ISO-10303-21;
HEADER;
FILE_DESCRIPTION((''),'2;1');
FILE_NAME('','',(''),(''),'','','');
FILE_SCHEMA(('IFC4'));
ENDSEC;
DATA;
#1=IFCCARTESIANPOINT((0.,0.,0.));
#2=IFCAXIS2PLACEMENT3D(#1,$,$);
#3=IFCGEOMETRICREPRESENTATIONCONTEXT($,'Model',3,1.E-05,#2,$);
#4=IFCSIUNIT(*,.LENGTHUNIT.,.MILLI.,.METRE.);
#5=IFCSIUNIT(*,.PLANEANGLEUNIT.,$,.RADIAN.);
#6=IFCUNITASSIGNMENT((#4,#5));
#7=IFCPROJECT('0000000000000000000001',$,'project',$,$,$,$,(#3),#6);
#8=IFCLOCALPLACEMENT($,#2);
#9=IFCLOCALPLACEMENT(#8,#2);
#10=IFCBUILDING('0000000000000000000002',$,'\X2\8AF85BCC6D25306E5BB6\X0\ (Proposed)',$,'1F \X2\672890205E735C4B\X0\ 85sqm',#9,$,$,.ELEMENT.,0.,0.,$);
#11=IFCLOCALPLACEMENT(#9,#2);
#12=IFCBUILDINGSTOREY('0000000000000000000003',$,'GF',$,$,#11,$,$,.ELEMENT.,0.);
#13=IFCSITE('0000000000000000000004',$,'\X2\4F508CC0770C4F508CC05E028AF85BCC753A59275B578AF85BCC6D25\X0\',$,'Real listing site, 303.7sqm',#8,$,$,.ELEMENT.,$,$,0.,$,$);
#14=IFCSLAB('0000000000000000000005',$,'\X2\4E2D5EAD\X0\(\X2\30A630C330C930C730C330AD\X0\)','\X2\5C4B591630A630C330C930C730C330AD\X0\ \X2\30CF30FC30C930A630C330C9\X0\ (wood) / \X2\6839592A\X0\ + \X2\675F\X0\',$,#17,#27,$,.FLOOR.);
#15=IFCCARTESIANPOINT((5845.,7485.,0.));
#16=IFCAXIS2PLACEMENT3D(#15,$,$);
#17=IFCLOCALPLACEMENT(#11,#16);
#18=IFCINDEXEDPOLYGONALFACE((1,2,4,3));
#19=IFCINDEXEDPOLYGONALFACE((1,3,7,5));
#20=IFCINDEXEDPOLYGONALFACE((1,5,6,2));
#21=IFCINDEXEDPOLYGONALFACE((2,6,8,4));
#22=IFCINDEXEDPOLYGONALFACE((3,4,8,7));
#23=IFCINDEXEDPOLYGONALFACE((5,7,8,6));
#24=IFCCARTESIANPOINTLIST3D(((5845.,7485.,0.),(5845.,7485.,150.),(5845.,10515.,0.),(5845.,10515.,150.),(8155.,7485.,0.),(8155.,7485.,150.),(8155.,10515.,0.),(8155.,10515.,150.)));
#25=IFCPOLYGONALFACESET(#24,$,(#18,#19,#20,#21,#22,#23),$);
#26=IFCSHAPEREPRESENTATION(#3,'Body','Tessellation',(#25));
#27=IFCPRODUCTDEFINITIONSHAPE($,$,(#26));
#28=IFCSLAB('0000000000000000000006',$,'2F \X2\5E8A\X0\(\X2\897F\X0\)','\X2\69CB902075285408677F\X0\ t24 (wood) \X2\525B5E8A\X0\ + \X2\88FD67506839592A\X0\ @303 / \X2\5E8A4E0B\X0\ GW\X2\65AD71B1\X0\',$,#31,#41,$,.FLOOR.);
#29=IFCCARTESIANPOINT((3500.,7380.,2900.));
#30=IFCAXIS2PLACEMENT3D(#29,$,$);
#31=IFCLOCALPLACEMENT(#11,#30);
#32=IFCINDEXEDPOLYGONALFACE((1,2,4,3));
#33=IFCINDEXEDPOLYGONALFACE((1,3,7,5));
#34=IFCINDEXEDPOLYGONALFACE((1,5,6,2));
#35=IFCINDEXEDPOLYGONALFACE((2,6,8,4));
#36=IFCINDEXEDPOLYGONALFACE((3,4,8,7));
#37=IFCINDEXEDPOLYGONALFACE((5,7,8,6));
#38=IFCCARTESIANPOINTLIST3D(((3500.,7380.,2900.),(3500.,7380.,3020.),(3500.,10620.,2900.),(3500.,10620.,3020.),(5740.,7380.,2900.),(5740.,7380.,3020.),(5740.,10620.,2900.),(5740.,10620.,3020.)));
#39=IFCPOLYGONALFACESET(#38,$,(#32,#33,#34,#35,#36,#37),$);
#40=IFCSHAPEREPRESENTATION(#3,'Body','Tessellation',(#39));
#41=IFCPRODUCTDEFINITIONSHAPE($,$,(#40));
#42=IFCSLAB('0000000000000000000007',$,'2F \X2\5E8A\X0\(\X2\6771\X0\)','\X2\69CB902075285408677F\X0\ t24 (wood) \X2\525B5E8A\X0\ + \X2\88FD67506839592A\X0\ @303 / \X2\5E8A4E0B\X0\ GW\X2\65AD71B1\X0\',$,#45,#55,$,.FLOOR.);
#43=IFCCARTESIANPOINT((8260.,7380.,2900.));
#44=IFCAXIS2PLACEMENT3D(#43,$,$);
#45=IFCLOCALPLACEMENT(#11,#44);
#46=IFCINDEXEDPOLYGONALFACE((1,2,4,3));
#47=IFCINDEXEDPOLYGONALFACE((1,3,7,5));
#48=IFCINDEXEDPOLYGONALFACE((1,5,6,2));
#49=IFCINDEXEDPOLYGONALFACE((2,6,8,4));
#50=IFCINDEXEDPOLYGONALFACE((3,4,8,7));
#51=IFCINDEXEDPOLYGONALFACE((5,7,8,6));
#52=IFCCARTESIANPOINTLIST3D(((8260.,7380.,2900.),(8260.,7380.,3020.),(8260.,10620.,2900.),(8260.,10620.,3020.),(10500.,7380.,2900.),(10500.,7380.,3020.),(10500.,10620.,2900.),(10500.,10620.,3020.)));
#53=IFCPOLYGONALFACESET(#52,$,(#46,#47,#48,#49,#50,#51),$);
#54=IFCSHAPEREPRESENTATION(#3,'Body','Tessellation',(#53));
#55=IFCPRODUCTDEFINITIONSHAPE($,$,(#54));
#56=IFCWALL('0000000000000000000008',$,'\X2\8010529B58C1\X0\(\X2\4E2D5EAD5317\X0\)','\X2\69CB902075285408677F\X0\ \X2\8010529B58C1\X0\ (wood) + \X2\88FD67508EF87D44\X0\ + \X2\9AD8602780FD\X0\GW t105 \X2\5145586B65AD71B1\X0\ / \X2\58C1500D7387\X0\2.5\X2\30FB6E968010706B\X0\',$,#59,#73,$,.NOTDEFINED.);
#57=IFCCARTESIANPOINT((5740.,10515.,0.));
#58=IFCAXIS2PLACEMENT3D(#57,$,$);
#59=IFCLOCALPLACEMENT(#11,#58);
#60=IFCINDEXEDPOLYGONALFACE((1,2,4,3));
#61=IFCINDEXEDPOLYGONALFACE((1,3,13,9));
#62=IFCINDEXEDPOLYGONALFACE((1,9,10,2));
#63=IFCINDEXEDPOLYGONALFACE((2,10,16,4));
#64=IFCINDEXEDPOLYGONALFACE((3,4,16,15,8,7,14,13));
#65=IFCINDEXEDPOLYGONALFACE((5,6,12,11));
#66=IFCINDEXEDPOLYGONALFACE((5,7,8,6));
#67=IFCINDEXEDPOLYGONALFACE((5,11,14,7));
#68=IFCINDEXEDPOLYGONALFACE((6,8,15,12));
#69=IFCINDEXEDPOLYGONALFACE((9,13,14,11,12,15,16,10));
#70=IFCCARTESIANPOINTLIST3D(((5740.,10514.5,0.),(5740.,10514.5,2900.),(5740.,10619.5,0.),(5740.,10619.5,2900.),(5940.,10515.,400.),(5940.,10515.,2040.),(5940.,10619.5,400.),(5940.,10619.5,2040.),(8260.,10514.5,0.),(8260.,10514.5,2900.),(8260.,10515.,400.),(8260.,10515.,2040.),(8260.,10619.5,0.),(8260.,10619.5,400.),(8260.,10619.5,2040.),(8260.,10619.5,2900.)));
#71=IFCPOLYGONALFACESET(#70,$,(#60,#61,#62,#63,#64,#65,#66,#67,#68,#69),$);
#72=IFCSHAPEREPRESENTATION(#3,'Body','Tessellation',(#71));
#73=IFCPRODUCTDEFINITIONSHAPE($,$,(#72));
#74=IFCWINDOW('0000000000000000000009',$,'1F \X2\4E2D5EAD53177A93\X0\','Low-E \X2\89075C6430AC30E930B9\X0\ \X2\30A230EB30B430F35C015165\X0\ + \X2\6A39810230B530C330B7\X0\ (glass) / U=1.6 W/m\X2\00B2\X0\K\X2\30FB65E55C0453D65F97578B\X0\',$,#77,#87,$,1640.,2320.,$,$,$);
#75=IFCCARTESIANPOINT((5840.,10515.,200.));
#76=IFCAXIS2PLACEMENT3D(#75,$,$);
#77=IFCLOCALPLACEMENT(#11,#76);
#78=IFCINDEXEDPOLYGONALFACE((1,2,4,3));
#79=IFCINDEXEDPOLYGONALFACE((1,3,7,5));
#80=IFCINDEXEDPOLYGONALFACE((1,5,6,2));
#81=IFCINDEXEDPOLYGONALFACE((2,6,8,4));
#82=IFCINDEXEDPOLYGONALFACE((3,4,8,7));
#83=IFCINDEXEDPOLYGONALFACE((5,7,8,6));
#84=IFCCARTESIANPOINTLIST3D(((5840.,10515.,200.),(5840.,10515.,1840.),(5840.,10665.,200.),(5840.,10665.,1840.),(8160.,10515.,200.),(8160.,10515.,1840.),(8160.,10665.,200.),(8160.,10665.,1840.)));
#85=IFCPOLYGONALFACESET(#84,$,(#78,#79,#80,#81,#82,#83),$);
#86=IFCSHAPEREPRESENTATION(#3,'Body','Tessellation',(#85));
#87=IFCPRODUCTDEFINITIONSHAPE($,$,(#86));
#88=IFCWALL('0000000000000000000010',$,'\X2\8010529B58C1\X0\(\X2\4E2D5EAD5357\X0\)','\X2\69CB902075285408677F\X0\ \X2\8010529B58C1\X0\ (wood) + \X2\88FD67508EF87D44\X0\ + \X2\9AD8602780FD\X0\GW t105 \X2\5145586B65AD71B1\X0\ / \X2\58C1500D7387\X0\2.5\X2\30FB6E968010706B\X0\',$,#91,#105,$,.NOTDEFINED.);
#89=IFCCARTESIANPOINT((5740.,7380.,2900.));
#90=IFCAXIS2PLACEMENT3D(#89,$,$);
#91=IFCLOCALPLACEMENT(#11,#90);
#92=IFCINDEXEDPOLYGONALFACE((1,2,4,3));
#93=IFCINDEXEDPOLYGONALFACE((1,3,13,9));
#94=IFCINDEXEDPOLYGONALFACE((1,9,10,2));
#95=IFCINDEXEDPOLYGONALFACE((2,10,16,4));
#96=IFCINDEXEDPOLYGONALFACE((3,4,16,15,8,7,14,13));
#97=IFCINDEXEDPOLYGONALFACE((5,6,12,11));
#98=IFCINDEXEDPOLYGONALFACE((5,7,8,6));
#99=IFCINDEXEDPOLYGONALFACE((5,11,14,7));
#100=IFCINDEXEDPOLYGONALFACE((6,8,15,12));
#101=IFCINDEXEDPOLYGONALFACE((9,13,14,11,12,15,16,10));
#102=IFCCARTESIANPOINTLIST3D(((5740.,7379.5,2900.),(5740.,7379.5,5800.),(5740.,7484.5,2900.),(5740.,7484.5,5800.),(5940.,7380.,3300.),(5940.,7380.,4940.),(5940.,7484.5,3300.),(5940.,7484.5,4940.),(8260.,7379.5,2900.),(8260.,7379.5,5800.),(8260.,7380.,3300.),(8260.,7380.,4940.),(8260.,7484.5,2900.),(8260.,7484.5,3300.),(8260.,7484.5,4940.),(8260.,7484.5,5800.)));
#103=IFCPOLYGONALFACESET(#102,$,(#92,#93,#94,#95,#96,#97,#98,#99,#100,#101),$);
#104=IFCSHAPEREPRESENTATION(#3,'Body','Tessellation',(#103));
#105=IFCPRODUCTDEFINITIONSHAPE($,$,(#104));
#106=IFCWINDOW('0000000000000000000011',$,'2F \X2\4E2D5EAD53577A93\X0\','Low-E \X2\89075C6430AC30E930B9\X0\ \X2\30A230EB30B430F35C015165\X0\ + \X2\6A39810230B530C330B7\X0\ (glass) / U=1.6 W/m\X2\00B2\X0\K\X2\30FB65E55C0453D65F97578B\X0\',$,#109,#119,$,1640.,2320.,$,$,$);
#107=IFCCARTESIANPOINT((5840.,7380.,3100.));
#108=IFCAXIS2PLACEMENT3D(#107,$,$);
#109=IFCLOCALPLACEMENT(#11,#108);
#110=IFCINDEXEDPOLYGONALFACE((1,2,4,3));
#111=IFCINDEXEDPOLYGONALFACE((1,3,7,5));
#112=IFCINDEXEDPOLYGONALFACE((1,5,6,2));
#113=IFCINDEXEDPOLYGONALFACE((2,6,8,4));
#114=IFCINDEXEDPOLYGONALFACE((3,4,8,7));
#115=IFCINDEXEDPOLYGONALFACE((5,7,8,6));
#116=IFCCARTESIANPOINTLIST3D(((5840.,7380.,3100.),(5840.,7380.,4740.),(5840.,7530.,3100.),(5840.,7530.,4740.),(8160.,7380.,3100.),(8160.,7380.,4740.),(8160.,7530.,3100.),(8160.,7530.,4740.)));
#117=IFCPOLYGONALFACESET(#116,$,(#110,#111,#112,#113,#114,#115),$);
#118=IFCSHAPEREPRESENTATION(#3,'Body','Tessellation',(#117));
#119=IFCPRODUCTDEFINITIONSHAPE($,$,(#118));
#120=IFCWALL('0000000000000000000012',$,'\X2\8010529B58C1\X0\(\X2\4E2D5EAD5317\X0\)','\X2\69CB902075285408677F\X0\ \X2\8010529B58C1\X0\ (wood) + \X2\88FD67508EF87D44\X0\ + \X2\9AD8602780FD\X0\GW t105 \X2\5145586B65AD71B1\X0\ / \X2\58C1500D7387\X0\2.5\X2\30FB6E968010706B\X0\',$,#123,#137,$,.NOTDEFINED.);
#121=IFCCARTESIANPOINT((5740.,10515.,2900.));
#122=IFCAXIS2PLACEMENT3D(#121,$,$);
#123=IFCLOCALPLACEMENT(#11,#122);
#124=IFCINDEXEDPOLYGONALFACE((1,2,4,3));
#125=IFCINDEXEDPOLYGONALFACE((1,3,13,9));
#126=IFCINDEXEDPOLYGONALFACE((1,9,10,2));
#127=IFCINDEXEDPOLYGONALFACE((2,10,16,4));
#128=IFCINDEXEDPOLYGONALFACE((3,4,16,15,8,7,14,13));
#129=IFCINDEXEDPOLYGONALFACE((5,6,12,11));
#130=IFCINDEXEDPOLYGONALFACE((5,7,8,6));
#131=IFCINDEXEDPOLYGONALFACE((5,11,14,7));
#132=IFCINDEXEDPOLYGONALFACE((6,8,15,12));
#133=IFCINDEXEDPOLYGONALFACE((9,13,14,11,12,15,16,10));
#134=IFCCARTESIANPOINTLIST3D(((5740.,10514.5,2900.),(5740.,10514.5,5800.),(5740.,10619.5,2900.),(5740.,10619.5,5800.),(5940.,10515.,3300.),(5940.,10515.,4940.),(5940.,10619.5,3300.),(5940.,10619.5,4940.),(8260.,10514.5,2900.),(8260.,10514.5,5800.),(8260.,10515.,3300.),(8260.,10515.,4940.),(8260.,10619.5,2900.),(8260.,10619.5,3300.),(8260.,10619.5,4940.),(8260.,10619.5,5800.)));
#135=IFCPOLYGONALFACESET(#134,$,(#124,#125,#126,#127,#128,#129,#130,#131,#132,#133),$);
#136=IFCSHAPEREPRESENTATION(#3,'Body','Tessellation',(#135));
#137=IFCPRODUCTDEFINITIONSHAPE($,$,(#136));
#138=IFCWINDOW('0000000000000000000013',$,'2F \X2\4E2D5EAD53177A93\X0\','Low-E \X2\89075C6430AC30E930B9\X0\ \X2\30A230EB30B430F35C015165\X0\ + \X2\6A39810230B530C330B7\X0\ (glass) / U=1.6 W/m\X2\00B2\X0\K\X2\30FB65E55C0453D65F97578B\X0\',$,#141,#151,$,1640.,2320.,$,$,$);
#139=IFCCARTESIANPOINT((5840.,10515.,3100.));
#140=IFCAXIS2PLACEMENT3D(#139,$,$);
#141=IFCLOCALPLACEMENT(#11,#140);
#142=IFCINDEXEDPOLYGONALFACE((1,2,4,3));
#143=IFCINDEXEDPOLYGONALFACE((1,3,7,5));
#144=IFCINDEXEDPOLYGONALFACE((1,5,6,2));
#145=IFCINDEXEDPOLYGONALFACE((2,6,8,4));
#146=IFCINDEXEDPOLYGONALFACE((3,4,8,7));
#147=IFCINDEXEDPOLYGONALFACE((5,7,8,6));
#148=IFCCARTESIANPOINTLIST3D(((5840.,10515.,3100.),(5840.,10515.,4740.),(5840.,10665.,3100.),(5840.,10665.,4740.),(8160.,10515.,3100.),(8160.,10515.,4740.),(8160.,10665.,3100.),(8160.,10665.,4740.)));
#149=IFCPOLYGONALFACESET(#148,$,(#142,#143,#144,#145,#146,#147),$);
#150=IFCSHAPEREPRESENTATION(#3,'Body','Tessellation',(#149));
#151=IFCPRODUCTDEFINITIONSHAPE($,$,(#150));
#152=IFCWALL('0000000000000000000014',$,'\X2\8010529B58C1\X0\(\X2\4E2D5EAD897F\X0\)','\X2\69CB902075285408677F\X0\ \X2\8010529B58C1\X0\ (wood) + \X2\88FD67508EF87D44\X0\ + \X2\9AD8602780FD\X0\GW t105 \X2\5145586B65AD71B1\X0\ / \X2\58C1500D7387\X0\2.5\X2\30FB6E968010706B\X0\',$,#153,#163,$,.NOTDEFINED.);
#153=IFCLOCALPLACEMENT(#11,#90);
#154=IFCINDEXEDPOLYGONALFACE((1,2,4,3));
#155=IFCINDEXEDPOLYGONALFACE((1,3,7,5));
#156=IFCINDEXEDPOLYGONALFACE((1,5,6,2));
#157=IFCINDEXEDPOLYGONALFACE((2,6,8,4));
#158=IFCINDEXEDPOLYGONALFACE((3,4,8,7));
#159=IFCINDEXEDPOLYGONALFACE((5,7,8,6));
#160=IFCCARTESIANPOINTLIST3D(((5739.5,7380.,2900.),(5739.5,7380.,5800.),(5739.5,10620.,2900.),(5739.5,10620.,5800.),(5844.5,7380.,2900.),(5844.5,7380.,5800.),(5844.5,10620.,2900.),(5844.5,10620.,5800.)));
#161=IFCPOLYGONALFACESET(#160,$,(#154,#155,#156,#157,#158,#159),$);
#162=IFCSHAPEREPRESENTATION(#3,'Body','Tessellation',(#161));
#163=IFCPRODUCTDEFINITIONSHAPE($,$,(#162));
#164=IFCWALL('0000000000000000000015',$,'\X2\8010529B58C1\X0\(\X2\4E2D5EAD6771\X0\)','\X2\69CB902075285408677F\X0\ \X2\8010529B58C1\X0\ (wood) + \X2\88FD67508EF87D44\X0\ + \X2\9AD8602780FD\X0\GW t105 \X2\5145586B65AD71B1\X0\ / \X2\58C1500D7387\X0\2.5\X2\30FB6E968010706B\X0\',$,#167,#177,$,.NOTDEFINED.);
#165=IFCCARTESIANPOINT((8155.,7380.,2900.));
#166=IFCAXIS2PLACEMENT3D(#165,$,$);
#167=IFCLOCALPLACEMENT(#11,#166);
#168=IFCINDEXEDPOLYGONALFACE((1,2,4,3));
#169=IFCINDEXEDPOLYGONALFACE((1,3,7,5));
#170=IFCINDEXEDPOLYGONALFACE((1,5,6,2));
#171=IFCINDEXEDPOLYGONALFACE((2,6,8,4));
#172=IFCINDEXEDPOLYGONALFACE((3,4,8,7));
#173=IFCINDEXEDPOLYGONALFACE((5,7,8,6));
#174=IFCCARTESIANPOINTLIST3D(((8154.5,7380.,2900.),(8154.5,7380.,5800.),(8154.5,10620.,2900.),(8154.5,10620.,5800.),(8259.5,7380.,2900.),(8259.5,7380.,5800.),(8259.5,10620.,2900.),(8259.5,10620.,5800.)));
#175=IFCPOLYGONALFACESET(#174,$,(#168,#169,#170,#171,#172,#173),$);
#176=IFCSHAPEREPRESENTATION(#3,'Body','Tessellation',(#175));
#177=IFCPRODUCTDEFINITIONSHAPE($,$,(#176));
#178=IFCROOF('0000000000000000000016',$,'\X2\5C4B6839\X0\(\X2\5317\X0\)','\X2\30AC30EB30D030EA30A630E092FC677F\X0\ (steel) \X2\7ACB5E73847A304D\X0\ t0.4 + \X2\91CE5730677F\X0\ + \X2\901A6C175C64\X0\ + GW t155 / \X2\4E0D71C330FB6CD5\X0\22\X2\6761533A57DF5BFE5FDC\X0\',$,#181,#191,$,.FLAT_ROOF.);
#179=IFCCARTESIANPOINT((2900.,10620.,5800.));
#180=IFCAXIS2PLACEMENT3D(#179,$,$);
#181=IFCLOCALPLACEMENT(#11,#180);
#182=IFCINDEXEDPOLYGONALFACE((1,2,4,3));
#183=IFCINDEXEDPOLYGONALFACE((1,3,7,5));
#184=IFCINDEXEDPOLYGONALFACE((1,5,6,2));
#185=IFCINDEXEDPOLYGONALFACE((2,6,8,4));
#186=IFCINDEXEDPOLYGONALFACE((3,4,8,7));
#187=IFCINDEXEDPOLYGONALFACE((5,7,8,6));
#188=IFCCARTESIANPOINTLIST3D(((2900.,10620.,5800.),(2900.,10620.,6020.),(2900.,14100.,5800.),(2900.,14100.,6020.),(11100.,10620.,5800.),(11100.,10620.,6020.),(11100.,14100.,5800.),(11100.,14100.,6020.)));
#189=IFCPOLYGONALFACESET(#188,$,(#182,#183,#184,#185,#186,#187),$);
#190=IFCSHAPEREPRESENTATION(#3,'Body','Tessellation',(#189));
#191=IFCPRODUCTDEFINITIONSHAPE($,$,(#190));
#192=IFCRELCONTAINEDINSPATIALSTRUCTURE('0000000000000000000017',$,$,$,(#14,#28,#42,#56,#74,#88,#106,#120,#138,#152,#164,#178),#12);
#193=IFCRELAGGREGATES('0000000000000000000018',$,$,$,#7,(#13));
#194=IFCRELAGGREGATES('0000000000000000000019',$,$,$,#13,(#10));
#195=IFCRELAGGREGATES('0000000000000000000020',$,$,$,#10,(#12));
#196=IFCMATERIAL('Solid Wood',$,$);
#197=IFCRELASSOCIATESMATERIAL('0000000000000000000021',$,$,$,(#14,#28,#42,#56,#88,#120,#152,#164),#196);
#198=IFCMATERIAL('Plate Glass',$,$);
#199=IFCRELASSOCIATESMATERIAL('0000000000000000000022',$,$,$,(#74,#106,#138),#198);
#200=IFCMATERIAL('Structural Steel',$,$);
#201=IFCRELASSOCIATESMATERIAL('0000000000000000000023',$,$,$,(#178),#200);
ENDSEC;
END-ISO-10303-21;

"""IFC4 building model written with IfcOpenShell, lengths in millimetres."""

from ifc_helpers import new_model, si_unit, frame, frame_2d, origin, place, context, project, spatial, rectangle, extrude, material, element, fill, save


model = new_model("IFC4")

# Units and contexts
model_context = context("Model", 3, precision=1e-05, world=origin())
ifc_project = project(units=[si_unit("LENGTHUNIT", "METRE", prefix="MILLI"), si_unit("PLANEANGLEUNIT", "RADIAN")], contexts=[model_context])

# Site, building, storey
site_placement = place(None, origin())
site = spatial("IfcSite", under=ifc_project, at=site_placement, Name="佐賀県佐賀市諸富町大字諸富津", ObjectType="Real listing site, 303.7sqm", CompositionType="ELEMENT", RefElevation=0.0)
building_placement = place(site_placement, origin())
building = spatial("IfcBuilding", under=site, at=building_placement, Name="諸富津の家 (Proposed)", ObjectType="1F 木造平屋 85sqm", CompositionType="ELEMENT", ElevationOfRefHeight=0.0, ElevationOfTerrain=0.0)
storey_placement = place(building_placement, origin())
storey = spatial("IfcBuildingStorey", under=building, at=storey_placement, Name="GF", CompositionType="ELEMENT", Elevation=0.0)

# Slabs
ifc_material_1 = material(Name="Solid Wood")
slab_1_placement = place(storey_placement, frame((5845.0, 7485.0, 0.0)))
element("IfcSlab", 1, at=slab_1_placement, inside=storey, material=ifc_material_1, Name="中庭(ウッドデッキ)", Description="屋外ウッドデッキ ハードウッド (wood) / 根太 + 束", PredefinedType="FLOOR", context=model_context, shape_type="SweptSolid", body=[
    extrude(rectangle(XDim=2310.0, YDim=3030.0, at=frame_2d((1155.0, 1515.0))), frame((5845.0, 7485.0, 0.0)), (0.0, 0.0, 1.0), 150.0),
])
slab_2_placement = place(storey_placement, frame((3500.0, 7380.0, 2900.0)))
element("IfcSlab", 2, at=slab_2_placement, inside=storey, material=ifc_material_1, Name="2F 床(西)", Description="構造用合板 t24 (wood) 剛床 + 製材根太 @303 / 床下 GW断熱", PredefinedType="FLOOR", context=model_context, shape_type="SweptSolid", body=[
    extrude(rectangle(XDim=2240.0, YDim=3240.0, at=frame_2d((1120.0, 1620.0))), frame((3500.0, 7380.0, 2900.0)), (0.0, 0.0, 1.0), 120.0),
])
slab_3_placement = place(storey_placement, frame((8260.0, 7380.0, 2900.0)))
element("IfcSlab", 3, at=slab_3_placement, inside=storey, material=ifc_material_1, Name="2F 床(東)", Description="構造用合板 t24 (wood) 剛床 + 製材根太 @303 / 床下 GW断熱", PredefinedType="FLOOR", context=model_context, shape_type="SweptSolid", body=[
    extrude(rectangle(XDim=2240.0, YDim=3240.0, at=frame_2d((1120.0, 1620.0))), frame((8260.0, 7380.0, 2900.0)), (0.0, 0.0, 1.0), 120.0),
])

# Walls, openings, windows
wall_1_placement = place(storey_placement, frame((5740.0, 10515.0, 0.0)))
wall_1 = element("IfcWall", 4, at=wall_1_placement, inside=storey, material=ifc_material_1, Name="耐力壁(中庭北)", Description="構造用合板 耐力壁 (wood) + 製材軸組 + 高性能GW t105 充填断熱 / 壁倍率2.5・準耐火", PredefinedType="NOTDEFINED", context=model_context, shape_type="SweptSolid", body=[
    extrude(rectangle(XDim=2520.0, YDim=105.0, at=frame_2d((1260.0, 52.0))), frame((5740.0, 10515.0, 0.0)), (0.0, 0.0, 1.0), 2900.0),
])
opening_1_placement = place(storey_placement, frame((5840.0, 10515.0, 200.0)))
opening_1 = element("IfcOpeningElement", 5, at=opening_1_placement, cuts=wall_1, PredefinedType="NOTDEFINED", context=model_context, shape_type="SweptSolid", body=[
    extrude(rectangle(XDim=2320.0, YDim=150.0, at=frame_2d((1160.0, 75.0))), frame((5840.0, 10515.0, 200.0)), (0.0, 0.0, 1.0), 1640.0),
])
ifc_material_2 = material(Name="Plate Glass")
window_1_placement = place(storey_placement, frame((5840.0, 10515.0, 200.0)))
window_1 = element("IfcWindow", 6, at=window_1_placement, inside=storey, material=ifc_material_2, Name="1F 中庭北窓", Description="Low-E 複層ガラス アルゴン封入 + 樹脂サッシ (glass) / U=1.6 W/m²K・日射取得型", OverallHeight=1640.0, OverallWidth=2320.0, context=model_context, shape_type="SweptSolid", body=[
    extrude(rectangle(XDim=2320.0, YDim=150.0, at=frame_2d((1160.0, 75.0))), frame((5840.0, 10515.0, 200.0)), (0.0, 0.0, 1.0), 1640.0),
])
fill(opening_1, window_1)
wall_2_placement = place(storey_placement, frame((5740.0, 7380.0, 2900.0)))
wall_2 = element("IfcWall", 7, at=wall_2_placement, inside=storey, material=ifc_material_1, Name="耐力壁(中庭南)", Description="構造用合板 耐力壁 (wood) + 製材軸組 + 高性能GW t105 充填断熱 / 壁倍率2.5・準耐火", PredefinedType="NOTDEFINED", context=model_context, shape_type="SweptSolid", body=[
    extrude(rectangle(XDim=2520.0, YDim=105.0, at=frame_2d((1260.0, 52.0))), frame((5740.0, 7380.0, 2900.0)), (0.0, 0.0, 1.0), 2900.0),
])
opening_2_placement = place(storey_placement, frame((5840.0, 7380.0, 3100.0)))
opening_2 = element("IfcOpeningElement", 8, at=opening_2_placement, cuts=wall_2, PredefinedType="NOTDEFINED", context=model_context, shape_type="SweptSolid", body=[
    extrude(rectangle(XDim=2320.0, YDim=150.0, at=frame_2d((1160.0, 75.0))), frame((5840.0, 7380.0, 3100.0)), (0.0, 0.0, 1.0), 1640.0),
])
window_2_placement = place(storey_placement, frame((5840.0, 7380.0, 3100.0)))
window_2 = element("IfcWindow", 9, at=window_2_placement, inside=storey, material=ifc_material_2, Name="2F 中庭南窓", Description="Low-E 複層ガラス アルゴン封入 + 樹脂サッシ (glass) / U=1.6 W/m²K・日射取得型", OverallHeight=1640.0, OverallWidth=2320.0, context=model_context, shape_type="SweptSolid", body=[
    extrude(rectangle(XDim=2320.0, YDim=150.0, at=frame_2d((1160.0, 75.0))), frame((5840.0, 7380.0, 3100.0)), (0.0, 0.0, 1.0), 1640.0),
])
fill(opening_2, window_2)
wall_3_placement = place(storey_placement, frame((5740.0, 10515.0, 2900.0)))
wall_3 = element("IfcWall", 10, at=wall_3_placement, inside=storey, material=ifc_material_1, Name="耐力壁(中庭北)", Description="構造用合板 耐力壁 (wood) + 製材軸組 + 高性能GW t105 充填断熱 / 壁倍率2.5・準耐火", PredefinedType="NOTDEFINED", context=model_context, shape_type="SweptSolid", body=[
    extrude(rectangle(XDim=2520.0, YDim=105.0, at=frame_2d((1260.0, 52.0))), frame((5740.0, 10515.0, 2900.0)), (0.0, 0.0, 1.0), 2900.0),
])
opening_3_placement = place(storey_placement, frame((5840.0, 10515.0, 3100.0)))
opening_3 = element("IfcOpeningElement", 11, at=opening_3_placement, cuts=wall_3, PredefinedType="NOTDEFINED", context=model_context, shape_type="SweptSolid", body=[
    extrude(rectangle(XDim=2320.0, YDim=150.0, at=frame_2d((1160.0, 75.0))), frame((5840.0, 10515.0, 3100.0)), (0.0, 0.0, 1.0), 1640.0),
])
window_3_placement = place(storey_placement, frame((5840.0, 10515.0, 3100.0)))
window_3 = element("IfcWindow", 12, at=window_3_placement, inside=storey, material=ifc_material_2, Name="2F 中庭北窓", Description="Low-E 複層ガラス アルゴン封入 + 樹脂サッシ (glass) / U=1.6 W/m²K・日射取得型", OverallHeight=1640.0, OverallWidth=2320.0, context=model_context, shape_type="SweptSolid", body=[
    extrude(rectangle(XDim=2320.0, YDim=150.0, at=frame_2d((1160.0, 75.0))), frame((5840.0, 10515.0, 3100.0)), (0.0, 0.0, 1.0), 1640.0),
])
fill(opening_3, window_3)

# Walls
wall_4_placement = place(storey_placement, frame((5740.0, 7380.0, 2900.0)))
element("IfcWall", 13, at=wall_4_placement, inside=storey, material=ifc_material_1, Name="耐力壁(中庭西)", Description="構造用合板 耐力壁 (wood) + 製材軸組 + 高性能GW t105 充填断熱 / 壁倍率2.5・準耐火", PredefinedType="NOTDEFINED", context=model_context, shape_type="SweptSolid", body=[
    extrude(rectangle(XDim=105.0, YDim=3240.0, at=frame_2d((52.0, 1620.0))), frame((5740.0, 7380.0, 2900.0)), (0.0, 0.0, 1.0), 2900.0),
])
wall_5_placement = place(storey_placement, frame((8155.0, 7380.0, 2900.0)))
element("IfcWall", 14, at=wall_5_placement, inside=storey, material=ifc_material_1, Name="耐力壁(中庭東)", Description="構造用合板 耐力壁 (wood) + 製材軸組 + 高性能GW t105 充填断熱 / 壁倍率2.5・準耐火", PredefinedType="NOTDEFINED", context=model_context, shape_type="SweptSolid", body=[
    extrude(rectangle(XDim=105.0, YDim=3240.0, at=frame_2d((52.0, 1620.0))), frame((8155.0, 7380.0, 2900.0)), (0.0, 0.0, 1.0), 2900.0),
])

# Roof
ifc_material_3 = material(Name="Structural Steel")
roof_1_placement = place(storey_placement, frame((2900.0, 10620.0, 5800.0)))
element("IfcRoof", 15, at=roof_1_placement, inside=storey, material=ifc_material_3, Name="屋根(北)", Description="ガルバリウム鋼板 (steel) 立平葺き t0.4 + 野地板 + 通気層 + GW t155 / 不燃・法22条区域対応", PredefinedType="FLAT_ROOF", context=model_context, shape_type="SweptSolid", body=[
    extrude(rectangle(XDim=8200.0, YDim=3480.0, at=frame_2d((4100.0, 1740.0))), frame((2900.0, 10620.0, 5800.0)), (0.0, 0.0, 1.0), 220.0),
])

save(model, "model.ifc")
